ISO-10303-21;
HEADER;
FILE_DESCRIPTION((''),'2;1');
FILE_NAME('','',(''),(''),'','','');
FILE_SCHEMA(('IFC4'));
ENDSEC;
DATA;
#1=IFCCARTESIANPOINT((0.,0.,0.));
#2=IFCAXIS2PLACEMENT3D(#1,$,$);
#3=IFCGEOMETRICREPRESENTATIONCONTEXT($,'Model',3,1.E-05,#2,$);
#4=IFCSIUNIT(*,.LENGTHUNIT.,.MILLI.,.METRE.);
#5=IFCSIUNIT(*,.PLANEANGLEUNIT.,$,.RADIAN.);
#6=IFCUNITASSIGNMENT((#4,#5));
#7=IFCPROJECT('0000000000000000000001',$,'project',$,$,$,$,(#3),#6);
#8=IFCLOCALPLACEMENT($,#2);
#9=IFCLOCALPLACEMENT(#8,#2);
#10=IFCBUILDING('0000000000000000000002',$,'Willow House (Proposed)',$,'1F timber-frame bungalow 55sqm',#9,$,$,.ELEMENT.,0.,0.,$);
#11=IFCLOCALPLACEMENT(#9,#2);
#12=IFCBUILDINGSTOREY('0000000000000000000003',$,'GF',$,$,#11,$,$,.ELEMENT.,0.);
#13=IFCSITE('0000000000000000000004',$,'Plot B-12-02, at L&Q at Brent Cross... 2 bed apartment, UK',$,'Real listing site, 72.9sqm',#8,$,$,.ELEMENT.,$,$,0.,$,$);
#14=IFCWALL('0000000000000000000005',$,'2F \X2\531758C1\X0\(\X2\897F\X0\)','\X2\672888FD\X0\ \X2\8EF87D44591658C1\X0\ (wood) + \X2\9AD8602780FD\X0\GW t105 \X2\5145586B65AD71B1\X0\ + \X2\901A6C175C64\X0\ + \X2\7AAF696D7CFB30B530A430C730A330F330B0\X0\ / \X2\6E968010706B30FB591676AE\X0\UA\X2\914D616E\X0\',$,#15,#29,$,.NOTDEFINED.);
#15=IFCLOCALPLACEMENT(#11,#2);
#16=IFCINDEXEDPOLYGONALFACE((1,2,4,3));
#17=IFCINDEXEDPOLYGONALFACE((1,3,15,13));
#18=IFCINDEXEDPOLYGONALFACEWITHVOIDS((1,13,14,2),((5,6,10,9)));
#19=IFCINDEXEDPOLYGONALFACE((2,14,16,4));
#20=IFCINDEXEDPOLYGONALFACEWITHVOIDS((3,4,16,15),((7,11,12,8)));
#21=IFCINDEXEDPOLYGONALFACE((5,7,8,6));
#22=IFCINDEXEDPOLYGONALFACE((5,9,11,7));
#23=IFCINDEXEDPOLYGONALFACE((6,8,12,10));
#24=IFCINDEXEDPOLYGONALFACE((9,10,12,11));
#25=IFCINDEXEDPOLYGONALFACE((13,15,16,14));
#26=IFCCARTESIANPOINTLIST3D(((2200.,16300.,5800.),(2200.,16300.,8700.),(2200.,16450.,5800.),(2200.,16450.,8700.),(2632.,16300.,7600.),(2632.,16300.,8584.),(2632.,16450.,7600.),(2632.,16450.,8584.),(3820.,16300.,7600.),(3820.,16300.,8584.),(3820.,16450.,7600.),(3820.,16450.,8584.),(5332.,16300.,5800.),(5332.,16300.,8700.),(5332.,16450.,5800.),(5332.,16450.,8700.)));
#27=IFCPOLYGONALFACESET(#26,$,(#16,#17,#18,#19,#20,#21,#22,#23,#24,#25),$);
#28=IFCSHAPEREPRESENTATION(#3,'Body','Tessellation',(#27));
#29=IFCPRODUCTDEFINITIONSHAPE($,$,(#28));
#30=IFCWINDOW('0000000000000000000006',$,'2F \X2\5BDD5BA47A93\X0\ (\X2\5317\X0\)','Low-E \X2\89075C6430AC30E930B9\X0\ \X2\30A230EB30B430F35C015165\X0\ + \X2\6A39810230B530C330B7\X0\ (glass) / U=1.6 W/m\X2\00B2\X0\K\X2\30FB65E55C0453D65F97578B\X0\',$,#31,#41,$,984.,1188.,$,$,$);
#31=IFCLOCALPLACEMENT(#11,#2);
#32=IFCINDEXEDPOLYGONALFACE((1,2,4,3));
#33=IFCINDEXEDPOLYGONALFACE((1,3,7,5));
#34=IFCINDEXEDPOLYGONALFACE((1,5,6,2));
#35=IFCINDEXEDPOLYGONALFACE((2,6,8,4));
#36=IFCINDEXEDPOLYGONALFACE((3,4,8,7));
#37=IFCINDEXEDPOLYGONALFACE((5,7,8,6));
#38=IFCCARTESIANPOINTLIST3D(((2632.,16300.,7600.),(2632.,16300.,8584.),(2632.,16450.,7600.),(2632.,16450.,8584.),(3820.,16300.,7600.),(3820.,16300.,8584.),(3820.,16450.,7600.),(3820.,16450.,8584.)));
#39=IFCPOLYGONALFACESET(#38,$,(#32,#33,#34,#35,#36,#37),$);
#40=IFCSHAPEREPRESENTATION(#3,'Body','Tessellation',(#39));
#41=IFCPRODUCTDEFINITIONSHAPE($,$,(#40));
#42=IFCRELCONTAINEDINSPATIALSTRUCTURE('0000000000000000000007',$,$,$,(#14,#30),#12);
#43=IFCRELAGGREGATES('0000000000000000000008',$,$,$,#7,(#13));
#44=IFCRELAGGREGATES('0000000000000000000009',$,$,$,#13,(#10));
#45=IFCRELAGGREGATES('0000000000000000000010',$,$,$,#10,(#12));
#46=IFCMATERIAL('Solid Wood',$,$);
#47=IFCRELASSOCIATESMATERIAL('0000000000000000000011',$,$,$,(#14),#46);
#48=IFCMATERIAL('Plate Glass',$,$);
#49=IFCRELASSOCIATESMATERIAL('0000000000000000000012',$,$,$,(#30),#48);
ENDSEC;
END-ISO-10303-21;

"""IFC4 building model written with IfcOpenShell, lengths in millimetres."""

from ifc_helpers import new_model, si_unit, frame, frame_2d, origin, place, context, project, spatial, rectangle, extrude, material, element, fill, save


model = new_model("IFC4")

# Units and contexts
model_context = context("Model", 3, precision=1e-05, world=origin())
ifc_project = project(units=[si_unit("LENGTHUNIT", "METRE", prefix="MILLI"), si_unit("PLANEANGLEUNIT", "RADIAN")], contexts=[model_context])

# Site, building, storey
site_placement = place(None, origin())
site = spatial("IfcSite", under=ifc_project, at=site_placement, Name="Plot B-12-02, at L&Q at Brent Cross... 2 bed apartment, UK", ObjectType="Real listing site, 72.9sqm", CompositionType="ELEMENT", RefElevation=0.0)
building_placement = place(site_placement, origin())
building = spatial("IfcBuilding", under=site, at=building_placement, Name="Willow House (Proposed)", ObjectType="1F timber-frame bungalow 55sqm", CompositionType="ELEMENT", ElevationOfRefHeight=0.0, ElevationOfTerrain=0.0)
storey_placement = place(building_placement, origin())
storey = spatial("IfcBuildingStorey", under=building, at=storey_placement, Name="GF", CompositionType="ELEMENT", Elevation=0.0)

# Shared definitions
ifc_material_1 = material(Name="Solid Wood")

# Wall, opening, window
wall_1_placement = place(storey_placement, frame((1100.0, 8150.0, 2900.0)))
wall_1 = element("IfcWall", 1, at=wall_1_placement, inside=storey, material=ifc_material_1, Name="2F 北壁(西)", Description="木製 軸組外壁 (wood) + 高性能GW t105 充填断熱 + 通気層 + 窯業系サイディング / 準耐火・外皮UA配慮", PredefinedType="NOTDEFINED", context=model_context, shape_type="SweptSolid", body=[
    extrude(rectangle(XDim=3132.0, YDim=150.0, at=frame_2d((1566.0, 75.0))), frame((1100.0, 8150.0, 2900.0)), (0.0, 0.0, 1.0), 2900.0),
])
opening_1_placement = place(storey_placement, frame((1316.0, 8150.0, 3800.0)))
opening_1 = element("IfcOpeningElement", 2, at=opening_1_placement, cuts=wall_1, PredefinedType="NOTDEFINED", context=model_context, shape_type="SweptSolid", body=[
    extrude(rectangle(XDim=1188.0, YDim=150.0, at=frame_2d((594.0, 75.0))), frame((1316.0, 8150.0, 3800.0)), (0.0, 0.0, 1.0), 984.0),
])
ifc_material_2 = material(Name="Plate Glass")
window_1_placement = place(storey_placement, frame((1316.0, 8150.0, 3800.0)))
window_1 = element("IfcWindow", 3, at=window_1_placement, inside=storey, material=ifc_material_2, Name="2F 寝室窓 (北)", Description="Low-E 複層ガラス アルゴン封入 + 樹脂サッシ (glass) / U=1.6 W/m²K・日射取得型", OverallHeight=984.0, OverallWidth=1188.0, context=model_context, shape_type="SweptSolid", body=[
    extrude(rectangle(XDim=1188.0, YDim=150.0, at=frame_2d((594.0, 75.0))), frame((1316.0, 8150.0, 3800.0)), (0.0, 0.0, 1.0), 984.0),
])
fill(opening_1, window_1)

save(model, "model.ifc")
